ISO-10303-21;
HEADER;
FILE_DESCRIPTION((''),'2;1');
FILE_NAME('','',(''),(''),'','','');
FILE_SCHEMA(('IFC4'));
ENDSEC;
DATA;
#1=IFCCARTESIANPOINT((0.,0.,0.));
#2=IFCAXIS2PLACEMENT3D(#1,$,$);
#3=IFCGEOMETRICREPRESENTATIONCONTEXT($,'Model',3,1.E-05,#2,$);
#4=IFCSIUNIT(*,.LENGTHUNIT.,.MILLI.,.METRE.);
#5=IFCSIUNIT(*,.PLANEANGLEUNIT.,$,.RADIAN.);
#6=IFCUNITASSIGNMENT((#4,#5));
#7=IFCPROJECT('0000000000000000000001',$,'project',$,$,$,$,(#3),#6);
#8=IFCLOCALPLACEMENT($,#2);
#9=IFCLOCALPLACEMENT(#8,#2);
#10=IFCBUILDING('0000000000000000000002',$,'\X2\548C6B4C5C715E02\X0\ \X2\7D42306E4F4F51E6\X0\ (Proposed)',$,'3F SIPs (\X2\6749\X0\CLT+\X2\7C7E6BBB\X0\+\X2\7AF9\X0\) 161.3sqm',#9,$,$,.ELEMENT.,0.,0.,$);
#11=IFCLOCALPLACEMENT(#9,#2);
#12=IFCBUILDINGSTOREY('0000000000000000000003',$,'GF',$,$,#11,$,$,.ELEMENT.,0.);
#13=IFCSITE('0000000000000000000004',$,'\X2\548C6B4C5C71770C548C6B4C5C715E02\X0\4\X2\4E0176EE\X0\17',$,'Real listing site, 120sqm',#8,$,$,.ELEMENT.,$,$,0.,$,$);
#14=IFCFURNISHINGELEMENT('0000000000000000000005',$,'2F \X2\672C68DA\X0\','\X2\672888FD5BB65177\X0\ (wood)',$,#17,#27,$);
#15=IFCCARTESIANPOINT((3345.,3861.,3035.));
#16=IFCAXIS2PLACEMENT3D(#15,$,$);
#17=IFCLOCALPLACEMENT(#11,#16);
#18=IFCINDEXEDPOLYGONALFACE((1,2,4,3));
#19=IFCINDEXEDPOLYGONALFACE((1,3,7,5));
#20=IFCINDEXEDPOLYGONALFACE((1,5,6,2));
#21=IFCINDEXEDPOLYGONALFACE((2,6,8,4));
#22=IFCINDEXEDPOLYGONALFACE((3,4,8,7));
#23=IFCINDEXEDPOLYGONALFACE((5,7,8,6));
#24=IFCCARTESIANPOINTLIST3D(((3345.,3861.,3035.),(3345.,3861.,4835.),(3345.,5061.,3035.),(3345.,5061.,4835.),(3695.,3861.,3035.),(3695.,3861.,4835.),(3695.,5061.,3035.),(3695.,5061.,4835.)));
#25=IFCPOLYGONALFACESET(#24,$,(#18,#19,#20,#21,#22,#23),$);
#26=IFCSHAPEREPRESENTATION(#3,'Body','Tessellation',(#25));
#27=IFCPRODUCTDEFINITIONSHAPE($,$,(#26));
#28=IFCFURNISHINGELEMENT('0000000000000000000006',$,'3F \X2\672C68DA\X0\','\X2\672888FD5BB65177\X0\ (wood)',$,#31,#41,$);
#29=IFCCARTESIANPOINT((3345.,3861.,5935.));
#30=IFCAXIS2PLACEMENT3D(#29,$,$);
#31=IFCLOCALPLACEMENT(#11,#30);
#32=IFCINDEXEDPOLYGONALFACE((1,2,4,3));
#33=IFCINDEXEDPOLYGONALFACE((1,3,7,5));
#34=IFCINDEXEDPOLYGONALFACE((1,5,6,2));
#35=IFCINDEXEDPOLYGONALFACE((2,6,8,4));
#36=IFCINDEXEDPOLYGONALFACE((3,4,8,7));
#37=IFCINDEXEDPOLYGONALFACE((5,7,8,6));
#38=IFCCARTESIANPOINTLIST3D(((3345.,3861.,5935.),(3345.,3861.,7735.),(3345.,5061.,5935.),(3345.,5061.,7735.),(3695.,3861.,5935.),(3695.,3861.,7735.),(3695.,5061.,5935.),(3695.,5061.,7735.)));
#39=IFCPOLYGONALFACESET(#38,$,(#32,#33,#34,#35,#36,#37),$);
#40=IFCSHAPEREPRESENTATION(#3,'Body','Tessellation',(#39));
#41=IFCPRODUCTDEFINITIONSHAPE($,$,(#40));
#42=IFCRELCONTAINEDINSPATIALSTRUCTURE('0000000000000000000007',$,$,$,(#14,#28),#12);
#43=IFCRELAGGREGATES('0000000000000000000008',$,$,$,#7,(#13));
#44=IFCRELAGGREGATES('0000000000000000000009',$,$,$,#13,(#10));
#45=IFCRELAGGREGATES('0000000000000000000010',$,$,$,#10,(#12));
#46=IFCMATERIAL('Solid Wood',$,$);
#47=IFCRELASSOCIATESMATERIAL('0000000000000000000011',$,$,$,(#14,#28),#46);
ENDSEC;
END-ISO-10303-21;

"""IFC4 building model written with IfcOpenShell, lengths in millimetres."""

from ifc_helpers import new_model, si_unit, frame, frame_2d, origin, place, context, project, spatial, rectangle, extrude, material, element, save


model = new_model("IFC4")

# Units and contexts
model_context = context("Model", 3, precision=1e-05, world=origin())
ifc_project = project(units=[si_unit("LENGTHUNIT", "METRE", prefix="MILLI"), si_unit("PLANEANGLEUNIT", "RADIAN")], contexts=[model_context])

# Site, building, storey
site_placement = place(None, origin())
site = spatial("IfcSite", under=ifc_project, at=site_placement, Name="和歌山県和歌山市4丁目17", ObjectType="Real listing site, 120sqm", CompositionType="ELEMENT", RefElevation=0.0)
building_placement = place(site_placement, origin())
building = spatial("IfcBuilding", under=site, at=building_placement, Name="和歌山市 終の住処 (Proposed)", ObjectType="3F SIPs (杉CLT+籾殻+竹) 161.3sqm", CompositionType="ELEMENT", ElevationOfRefHeight=0.0, ElevationOfTerrain=0.0)
storey_placement = place(building_placement, origin())
storey = spatial("IfcBuildingStorey", under=building, at=storey_placement, Name="GF", CompositionType="ELEMENT", Elevation=0.0)

# Shared definitions
ifc_material_1 = material(Name="Solid Wood")

# Furnishing elements
furnishing_1_placement = place(storey_placement, frame((3345.0, 3861.0, 3035.0)))
element("IfcFurnishingElement", 1, at=furnishing_1_placement, inside=storey, material=ifc_material_1, Name="2F 本棚", Description="木製家具 (wood)", context=model_context, shape_type="SweptSolid", body=[
    extrude(rectangle(XDim=350.0, YDim=1200.0, at=frame_2d((175.0, 600.0))), frame((3345.0, 3861.0, 3035.0)), (0.0, 0.0, 1.0), 1800.0),
])
furnishing_2_placement = place(storey_placement, frame((3345.0, 3861.0, 5935.0)))
element("IfcFurnishingElement", 2, at=furnishing_2_placement, inside=storey, material=ifc_material_1, Name="3F 本棚", Description="木製家具 (wood)", context=model_context, shape_type="SweptSolid", body=[
    extrude(rectangle(XDim=350.0, YDim=1200.0, at=frame_2d((175.0, 600.0))), frame((3345.0, 3861.0, 5935.0)), (0.0, 0.0, 1.0), 1800.0),
])

save(model, "model.ifc")
